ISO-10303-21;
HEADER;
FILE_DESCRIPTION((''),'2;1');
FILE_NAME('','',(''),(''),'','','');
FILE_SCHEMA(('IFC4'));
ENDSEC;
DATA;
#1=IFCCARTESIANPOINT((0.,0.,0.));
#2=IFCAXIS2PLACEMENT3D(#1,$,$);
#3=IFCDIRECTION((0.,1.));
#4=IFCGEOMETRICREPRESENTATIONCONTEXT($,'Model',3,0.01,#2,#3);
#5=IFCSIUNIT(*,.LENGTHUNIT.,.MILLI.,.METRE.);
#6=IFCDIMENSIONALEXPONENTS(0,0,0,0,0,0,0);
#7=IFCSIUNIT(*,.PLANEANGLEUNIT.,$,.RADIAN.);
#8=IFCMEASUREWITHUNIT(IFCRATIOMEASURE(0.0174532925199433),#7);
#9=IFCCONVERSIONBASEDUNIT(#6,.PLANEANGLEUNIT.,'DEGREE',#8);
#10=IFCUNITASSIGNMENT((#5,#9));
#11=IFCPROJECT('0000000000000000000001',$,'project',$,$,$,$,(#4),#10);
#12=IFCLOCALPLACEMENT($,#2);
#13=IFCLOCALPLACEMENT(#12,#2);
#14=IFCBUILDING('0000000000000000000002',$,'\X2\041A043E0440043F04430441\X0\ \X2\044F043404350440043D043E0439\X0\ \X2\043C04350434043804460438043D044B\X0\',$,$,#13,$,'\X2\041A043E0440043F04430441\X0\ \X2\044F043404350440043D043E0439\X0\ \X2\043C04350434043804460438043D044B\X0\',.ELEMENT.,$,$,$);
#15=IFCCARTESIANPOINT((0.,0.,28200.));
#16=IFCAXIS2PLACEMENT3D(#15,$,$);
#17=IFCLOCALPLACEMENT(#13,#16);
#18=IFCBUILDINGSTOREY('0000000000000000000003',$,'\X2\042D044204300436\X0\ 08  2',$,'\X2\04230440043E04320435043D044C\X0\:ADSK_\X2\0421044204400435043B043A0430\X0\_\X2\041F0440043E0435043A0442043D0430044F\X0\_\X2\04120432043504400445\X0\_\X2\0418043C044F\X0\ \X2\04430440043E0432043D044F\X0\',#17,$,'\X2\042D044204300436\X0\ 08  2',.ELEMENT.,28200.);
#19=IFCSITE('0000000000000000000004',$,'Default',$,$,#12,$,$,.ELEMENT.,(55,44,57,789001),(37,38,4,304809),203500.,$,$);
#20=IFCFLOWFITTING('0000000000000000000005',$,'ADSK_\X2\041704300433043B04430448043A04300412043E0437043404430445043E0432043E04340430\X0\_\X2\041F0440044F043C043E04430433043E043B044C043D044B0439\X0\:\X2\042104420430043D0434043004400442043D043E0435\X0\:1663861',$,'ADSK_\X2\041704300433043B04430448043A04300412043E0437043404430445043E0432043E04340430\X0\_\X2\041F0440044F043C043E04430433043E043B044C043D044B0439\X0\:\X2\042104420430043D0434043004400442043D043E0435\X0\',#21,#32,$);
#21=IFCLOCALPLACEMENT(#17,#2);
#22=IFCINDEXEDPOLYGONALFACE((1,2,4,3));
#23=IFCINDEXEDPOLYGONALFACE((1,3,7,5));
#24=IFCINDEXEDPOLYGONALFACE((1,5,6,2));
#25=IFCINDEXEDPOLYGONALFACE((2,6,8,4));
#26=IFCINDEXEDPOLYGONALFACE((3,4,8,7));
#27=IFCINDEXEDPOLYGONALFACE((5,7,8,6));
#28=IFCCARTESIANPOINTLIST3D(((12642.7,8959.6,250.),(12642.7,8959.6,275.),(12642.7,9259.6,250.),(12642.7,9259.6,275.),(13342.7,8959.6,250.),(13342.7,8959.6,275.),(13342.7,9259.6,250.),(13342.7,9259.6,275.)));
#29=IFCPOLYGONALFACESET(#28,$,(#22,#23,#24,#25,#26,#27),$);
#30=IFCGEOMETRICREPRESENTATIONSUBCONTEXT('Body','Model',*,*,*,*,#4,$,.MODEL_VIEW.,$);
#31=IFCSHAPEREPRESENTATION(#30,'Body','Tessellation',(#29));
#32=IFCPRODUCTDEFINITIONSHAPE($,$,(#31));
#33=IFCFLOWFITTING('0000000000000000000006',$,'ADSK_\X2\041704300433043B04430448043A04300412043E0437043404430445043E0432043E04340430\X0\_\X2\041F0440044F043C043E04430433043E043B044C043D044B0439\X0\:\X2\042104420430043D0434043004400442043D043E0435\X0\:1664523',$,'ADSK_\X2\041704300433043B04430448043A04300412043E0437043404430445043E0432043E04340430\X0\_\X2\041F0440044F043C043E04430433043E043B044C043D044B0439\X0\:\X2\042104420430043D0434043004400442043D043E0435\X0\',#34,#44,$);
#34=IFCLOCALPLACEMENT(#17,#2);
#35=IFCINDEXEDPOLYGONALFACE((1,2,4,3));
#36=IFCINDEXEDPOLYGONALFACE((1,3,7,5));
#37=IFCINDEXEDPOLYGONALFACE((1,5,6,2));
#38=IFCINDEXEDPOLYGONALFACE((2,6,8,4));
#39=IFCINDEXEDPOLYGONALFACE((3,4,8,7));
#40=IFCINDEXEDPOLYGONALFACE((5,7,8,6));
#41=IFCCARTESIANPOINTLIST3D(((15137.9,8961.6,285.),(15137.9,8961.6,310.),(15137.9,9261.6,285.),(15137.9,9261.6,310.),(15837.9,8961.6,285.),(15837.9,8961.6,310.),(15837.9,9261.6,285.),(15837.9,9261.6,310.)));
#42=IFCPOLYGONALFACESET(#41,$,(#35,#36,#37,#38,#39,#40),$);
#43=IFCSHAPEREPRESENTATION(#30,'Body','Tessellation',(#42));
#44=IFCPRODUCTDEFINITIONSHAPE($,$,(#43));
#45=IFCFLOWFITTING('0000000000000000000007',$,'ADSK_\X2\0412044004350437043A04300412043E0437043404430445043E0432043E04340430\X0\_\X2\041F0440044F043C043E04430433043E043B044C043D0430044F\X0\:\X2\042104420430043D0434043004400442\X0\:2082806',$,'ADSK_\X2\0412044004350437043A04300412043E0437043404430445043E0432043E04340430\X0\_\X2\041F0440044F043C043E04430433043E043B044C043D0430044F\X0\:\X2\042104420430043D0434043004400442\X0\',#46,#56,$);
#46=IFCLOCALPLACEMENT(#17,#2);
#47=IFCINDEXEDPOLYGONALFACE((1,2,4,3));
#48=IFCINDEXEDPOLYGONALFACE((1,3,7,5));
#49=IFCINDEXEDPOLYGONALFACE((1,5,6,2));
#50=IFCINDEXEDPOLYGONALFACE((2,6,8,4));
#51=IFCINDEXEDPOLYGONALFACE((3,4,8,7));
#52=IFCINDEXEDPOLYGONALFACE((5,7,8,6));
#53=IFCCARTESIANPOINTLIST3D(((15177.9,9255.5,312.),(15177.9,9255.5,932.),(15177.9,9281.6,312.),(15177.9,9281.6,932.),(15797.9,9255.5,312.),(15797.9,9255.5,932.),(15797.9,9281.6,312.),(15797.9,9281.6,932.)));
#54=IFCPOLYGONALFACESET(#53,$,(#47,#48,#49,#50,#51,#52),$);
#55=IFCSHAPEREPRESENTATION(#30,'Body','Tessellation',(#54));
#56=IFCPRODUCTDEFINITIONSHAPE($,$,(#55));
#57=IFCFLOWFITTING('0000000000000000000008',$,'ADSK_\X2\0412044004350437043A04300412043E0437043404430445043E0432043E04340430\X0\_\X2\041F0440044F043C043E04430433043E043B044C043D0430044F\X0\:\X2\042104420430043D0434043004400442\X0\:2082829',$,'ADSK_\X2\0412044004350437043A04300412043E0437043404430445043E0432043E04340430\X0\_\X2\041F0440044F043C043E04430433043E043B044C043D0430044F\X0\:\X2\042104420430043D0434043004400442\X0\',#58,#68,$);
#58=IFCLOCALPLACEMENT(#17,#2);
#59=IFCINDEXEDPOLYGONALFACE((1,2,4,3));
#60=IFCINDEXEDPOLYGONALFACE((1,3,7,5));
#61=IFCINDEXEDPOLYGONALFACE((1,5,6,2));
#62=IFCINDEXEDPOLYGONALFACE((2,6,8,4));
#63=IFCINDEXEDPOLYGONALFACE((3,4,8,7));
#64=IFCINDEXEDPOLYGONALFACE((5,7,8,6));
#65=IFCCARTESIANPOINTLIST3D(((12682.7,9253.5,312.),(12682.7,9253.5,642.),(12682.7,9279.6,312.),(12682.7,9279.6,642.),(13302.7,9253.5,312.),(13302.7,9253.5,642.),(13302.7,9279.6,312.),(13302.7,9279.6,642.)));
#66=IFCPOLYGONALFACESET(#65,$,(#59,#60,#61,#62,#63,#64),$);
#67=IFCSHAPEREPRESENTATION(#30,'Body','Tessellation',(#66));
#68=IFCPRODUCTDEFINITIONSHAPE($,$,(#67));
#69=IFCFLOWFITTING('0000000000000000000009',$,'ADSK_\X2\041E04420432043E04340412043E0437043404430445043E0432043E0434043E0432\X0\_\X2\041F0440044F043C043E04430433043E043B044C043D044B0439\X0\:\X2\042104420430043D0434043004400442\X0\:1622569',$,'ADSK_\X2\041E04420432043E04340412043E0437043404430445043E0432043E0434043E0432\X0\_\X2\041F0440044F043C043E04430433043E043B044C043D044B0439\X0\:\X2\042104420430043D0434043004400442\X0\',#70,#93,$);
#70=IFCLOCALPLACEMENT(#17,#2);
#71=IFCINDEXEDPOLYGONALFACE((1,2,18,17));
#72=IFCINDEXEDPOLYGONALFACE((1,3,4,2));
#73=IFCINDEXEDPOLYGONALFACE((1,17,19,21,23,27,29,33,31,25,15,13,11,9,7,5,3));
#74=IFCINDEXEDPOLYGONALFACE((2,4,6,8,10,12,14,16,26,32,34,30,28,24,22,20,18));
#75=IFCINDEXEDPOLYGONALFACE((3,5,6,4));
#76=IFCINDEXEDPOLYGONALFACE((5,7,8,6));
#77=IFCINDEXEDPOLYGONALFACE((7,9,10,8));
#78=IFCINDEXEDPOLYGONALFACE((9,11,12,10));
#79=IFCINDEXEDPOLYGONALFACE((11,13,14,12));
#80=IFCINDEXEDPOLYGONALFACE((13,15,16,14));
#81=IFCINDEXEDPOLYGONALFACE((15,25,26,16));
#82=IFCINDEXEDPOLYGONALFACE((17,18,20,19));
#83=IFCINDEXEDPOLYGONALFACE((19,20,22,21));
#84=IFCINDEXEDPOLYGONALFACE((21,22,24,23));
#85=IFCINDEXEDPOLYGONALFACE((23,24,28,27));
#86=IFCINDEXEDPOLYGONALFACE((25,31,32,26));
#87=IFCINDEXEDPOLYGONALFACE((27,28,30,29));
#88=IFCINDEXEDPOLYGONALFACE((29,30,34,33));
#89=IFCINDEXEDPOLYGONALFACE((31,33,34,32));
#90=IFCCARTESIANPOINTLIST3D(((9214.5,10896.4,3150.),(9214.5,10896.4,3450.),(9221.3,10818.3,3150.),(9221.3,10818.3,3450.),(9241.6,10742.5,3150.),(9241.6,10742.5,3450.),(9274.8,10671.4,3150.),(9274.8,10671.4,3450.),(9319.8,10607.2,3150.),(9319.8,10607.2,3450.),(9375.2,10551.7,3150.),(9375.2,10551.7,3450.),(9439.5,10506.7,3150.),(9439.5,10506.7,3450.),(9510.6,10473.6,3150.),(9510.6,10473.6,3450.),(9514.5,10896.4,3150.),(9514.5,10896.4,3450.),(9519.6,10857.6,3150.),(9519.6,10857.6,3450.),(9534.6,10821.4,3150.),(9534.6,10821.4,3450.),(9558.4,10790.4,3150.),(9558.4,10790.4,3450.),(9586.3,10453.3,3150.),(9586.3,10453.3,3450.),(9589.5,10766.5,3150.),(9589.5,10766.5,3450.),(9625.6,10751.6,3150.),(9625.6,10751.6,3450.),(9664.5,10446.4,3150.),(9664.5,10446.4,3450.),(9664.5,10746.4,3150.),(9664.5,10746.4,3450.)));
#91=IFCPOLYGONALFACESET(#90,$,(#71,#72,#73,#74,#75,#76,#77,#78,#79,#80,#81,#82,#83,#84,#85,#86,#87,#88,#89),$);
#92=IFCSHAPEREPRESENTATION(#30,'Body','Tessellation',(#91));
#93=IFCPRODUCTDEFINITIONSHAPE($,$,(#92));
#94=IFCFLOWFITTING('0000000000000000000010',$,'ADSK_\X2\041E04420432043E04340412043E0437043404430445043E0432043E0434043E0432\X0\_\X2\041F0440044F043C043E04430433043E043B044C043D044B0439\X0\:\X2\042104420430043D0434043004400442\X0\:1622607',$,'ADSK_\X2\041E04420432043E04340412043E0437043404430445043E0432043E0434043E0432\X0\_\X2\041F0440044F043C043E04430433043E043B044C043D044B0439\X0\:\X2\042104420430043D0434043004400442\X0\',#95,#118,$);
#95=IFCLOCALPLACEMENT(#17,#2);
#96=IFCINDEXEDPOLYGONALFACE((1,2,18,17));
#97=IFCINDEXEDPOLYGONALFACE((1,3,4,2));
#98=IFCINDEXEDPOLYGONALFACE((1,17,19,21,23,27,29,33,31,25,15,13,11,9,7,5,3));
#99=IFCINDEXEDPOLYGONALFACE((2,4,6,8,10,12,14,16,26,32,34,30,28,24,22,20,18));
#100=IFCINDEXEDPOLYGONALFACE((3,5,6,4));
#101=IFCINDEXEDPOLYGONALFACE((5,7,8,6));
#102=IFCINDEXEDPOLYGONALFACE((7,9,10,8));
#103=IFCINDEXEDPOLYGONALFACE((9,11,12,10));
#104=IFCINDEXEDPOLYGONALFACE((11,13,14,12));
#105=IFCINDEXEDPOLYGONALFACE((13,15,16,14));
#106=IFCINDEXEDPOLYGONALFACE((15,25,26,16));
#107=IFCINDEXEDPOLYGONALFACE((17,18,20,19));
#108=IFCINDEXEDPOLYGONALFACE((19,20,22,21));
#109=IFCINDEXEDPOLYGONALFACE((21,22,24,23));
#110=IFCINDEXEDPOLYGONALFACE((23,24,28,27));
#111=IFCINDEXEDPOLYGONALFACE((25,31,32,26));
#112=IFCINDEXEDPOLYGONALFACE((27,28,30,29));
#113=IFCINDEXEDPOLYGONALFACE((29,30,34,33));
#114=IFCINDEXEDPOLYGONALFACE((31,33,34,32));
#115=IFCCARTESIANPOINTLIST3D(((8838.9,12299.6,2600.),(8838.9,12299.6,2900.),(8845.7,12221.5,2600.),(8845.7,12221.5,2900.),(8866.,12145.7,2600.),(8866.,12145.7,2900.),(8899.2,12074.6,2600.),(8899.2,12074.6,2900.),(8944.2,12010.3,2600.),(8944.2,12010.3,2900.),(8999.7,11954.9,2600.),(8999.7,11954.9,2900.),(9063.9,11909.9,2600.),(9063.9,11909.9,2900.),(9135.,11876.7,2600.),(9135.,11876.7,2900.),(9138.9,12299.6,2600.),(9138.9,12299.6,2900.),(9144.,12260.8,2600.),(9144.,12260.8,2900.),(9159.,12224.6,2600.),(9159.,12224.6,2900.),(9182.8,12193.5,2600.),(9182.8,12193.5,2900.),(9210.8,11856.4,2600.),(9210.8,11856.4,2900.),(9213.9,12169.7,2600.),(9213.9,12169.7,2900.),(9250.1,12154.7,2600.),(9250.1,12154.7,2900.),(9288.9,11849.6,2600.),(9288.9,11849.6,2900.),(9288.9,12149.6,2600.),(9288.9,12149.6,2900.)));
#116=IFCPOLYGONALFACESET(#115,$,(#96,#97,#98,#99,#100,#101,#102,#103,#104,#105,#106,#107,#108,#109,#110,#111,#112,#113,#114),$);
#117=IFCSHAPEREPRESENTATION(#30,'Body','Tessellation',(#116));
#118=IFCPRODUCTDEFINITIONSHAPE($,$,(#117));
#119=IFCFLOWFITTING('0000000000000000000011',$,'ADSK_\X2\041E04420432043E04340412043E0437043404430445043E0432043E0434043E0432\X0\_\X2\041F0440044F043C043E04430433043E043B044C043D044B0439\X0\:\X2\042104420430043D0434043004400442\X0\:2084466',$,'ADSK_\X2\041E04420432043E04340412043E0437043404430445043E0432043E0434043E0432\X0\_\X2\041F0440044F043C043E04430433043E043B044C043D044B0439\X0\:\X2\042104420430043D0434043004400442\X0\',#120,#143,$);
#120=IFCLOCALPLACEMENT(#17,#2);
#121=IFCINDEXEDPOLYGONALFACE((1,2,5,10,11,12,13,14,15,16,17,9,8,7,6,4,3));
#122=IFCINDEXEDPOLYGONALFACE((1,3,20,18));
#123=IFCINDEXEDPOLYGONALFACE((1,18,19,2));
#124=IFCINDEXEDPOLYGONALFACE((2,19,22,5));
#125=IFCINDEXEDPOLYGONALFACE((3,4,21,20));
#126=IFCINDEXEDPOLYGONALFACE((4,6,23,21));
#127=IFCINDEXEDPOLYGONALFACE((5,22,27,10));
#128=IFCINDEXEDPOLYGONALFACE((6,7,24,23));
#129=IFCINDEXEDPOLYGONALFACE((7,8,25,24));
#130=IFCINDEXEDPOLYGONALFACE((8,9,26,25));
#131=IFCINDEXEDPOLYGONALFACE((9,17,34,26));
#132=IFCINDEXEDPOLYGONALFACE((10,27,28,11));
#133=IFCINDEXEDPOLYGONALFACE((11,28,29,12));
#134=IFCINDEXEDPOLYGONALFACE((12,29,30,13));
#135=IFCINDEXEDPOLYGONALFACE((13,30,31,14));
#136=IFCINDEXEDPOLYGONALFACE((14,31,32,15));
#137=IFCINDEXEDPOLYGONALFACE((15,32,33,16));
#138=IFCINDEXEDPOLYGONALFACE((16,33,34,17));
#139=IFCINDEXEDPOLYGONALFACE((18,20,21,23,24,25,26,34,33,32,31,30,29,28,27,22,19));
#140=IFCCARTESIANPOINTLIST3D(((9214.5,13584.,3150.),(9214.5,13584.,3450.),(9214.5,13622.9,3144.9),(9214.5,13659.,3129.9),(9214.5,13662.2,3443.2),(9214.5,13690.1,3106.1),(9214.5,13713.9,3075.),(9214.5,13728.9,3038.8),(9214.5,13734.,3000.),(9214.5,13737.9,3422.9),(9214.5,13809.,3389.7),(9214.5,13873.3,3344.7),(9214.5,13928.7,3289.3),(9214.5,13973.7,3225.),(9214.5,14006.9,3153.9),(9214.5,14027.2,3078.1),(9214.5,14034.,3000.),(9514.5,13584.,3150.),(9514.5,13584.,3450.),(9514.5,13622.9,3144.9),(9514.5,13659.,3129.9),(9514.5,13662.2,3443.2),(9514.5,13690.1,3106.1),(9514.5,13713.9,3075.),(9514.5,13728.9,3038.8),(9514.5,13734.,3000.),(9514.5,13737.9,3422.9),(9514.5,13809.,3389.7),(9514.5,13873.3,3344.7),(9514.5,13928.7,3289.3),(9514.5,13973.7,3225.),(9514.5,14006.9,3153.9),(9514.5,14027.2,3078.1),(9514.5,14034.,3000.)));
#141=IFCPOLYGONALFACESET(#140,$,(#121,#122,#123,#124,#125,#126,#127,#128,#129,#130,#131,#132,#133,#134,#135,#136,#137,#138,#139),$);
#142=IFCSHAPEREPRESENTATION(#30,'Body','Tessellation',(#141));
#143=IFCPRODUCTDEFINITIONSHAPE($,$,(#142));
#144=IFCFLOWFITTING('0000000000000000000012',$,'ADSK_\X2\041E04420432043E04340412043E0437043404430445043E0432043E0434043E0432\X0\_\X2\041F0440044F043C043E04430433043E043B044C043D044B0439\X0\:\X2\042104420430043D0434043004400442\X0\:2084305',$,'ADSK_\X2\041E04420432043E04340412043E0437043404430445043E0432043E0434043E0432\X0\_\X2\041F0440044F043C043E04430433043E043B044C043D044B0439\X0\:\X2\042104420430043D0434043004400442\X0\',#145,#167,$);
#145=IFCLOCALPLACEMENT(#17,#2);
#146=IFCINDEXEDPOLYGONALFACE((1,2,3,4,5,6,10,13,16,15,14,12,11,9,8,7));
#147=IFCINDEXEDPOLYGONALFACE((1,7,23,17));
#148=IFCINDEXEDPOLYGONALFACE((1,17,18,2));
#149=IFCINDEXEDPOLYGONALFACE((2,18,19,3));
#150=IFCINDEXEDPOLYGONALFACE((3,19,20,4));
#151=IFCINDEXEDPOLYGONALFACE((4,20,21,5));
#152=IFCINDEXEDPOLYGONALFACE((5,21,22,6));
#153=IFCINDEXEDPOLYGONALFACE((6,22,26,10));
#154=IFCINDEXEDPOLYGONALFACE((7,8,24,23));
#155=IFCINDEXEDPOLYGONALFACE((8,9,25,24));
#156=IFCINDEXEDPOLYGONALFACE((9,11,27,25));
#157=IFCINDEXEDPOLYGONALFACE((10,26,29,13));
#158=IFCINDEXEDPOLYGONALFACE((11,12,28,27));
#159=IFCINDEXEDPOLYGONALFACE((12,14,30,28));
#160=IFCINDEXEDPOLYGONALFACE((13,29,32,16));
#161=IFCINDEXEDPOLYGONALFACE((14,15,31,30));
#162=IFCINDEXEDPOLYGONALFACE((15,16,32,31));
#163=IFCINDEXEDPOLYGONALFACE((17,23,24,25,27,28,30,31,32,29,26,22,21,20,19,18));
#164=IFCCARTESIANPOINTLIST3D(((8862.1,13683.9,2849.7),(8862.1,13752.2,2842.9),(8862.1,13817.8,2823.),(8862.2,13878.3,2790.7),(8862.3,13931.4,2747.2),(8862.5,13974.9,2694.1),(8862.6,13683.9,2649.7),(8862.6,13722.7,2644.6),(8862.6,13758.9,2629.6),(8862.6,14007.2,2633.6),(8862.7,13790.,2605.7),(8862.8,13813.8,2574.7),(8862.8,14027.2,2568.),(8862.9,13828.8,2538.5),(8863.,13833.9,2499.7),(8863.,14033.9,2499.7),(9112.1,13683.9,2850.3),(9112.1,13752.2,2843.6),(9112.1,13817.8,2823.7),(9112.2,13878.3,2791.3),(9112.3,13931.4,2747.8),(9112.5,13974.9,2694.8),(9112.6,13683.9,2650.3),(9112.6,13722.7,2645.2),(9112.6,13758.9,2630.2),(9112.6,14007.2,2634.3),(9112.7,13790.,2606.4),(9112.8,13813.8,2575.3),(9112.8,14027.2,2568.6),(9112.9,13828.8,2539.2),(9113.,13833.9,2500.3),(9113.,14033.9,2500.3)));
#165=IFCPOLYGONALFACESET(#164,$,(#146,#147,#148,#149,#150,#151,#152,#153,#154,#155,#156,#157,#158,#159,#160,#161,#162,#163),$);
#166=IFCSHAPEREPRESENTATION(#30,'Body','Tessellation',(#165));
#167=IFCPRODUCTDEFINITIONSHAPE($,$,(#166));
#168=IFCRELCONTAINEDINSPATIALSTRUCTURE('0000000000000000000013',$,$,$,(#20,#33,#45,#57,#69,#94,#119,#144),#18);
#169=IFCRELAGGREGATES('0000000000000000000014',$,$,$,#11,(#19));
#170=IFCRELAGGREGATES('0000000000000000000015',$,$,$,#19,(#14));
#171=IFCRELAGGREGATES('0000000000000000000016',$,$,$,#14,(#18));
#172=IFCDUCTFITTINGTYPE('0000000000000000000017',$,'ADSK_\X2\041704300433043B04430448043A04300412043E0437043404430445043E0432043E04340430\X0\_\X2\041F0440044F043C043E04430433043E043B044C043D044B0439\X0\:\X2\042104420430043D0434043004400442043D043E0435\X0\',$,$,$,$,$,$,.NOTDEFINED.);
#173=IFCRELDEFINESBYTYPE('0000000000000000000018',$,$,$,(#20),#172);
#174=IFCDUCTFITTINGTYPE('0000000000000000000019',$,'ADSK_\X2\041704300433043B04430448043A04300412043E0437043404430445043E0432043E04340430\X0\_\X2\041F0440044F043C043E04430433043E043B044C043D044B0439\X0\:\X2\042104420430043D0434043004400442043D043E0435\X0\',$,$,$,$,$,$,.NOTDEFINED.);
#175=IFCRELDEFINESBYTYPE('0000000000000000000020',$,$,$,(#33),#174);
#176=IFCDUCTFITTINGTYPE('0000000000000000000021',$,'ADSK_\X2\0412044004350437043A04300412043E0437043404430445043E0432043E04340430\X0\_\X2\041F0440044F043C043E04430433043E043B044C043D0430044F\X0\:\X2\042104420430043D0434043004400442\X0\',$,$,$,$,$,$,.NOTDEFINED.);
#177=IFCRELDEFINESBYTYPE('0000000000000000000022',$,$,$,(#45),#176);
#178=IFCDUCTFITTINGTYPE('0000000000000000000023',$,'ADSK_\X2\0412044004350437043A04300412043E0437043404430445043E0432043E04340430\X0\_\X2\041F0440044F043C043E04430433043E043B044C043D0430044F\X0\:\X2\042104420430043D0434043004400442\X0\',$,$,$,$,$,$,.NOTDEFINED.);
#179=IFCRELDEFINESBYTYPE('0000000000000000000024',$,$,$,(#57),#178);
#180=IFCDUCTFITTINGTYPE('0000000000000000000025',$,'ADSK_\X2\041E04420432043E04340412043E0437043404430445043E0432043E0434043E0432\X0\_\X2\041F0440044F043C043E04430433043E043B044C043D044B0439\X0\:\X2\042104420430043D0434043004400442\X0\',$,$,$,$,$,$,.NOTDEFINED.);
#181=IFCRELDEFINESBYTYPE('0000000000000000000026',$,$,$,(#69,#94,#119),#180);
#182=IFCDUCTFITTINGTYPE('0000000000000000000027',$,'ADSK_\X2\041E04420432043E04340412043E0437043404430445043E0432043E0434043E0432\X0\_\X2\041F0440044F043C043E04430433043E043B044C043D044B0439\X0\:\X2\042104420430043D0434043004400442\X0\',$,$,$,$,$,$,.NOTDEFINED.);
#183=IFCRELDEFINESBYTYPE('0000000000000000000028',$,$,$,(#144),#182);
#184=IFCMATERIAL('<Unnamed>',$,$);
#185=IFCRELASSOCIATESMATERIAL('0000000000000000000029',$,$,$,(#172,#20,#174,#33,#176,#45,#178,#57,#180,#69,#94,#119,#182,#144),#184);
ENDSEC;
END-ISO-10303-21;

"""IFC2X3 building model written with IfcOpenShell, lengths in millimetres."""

from ifc_helpers import new_model, entity, si_unit, converted_unit, direction, frame, frame_2d, origin, origin_2d_with_axis, place, context, subcontext, project, spatial, polyline, circle_curve, parameter, trimmed, segment, composite_curve, rectangle, outline, extrude, source, transform, mapped, material, type_object, type_shapes, element, save


model = new_model("IFC2X3")

# Units and contexts
model_context = context("Model", 3, precision=0.01, world=origin(), true_north=direction((0.0, 1.0)))
body_context = subcontext(model_context, "Body", "Model", "MODEL_VIEW")
ifc_project = project(units=[si_unit("LENGTHUNIT", "METRE", prefix="MILLI"), converted_unit("PLANEANGLEUNIT", "DEGREE", entity("IfcRatioMeasure", 0.0174532925199433), si_unit("PLANEANGLEUNIT", "RADIAN"), dimensions=[0, 0, 0, 0, 0, 0, 0])], contexts=[model_context])

# Site, building, storey
site_placement = place(None, origin())
site = spatial("IfcSite", under=ifc_project, at=site_placement, Name="Default", CompositionType="ELEMENT", RefLatitude=(55, 44, 57, 789001), RefLongitude=(37, 38, 4, 304809), RefElevation=203500.0)
building_placement = place(site_placement, origin())
building = spatial("IfcBuilding", under=site, at=building_placement, Name="Корпус ядерной медицины", LongName="Корпус ядерной медицины", CompositionType="ELEMENT")
storey_placement = place(building_placement, frame((0.0, 0.0, 28200.0)))
storey = spatial("IfcBuildingStorey", under=building, at=storey_placement, Name="Этаж 08  2", ObjectType="Уровень:ADSK_Стрелка_Проектная_Вверх_Имя уровня", LongName="Этаж 08  2", CompositionType="ELEMENT", Elevation=28200.0)

# Flow fittings
ifc_material = material(Name="<Unnamed>")
duct_fitting_type_1 = type_object("IfcDuctFittingType", Name="ADSK_ЗаглушкаВоздуховода_Прямоугольный:Стандартное", PredefinedType="NOTDEFINED", material=ifc_material)
shared_shape_1 = source(origin(), body_context, "Body", "SweptSolid", [
    extrude(rectangle(XDim=25.0, YDim=700.0, at=origin_2d_with_axis()), frame((12.5, 0.0, -150.0)), (0.0, 0.0, 1.0), 300.0),
])
type_shapes(duct_fitting_type_1, [shared_shape_1])
flow_fitting_1_placement = place(storey_placement, frame((12992.7, 9109.6, 275.0), z_axis=(0.0, 1.0, 0.0), x_axis=(0.0, 0.0, -1.0)))
element("IfcFlowFitting", 1, at=flow_fitting_1_placement, inside=storey, type_object=duct_fitting_type_1, material=ifc_material, Name="ADSK_ЗаглушкаВоздуховода_Прямоугольный:Стандартное:1663861", ObjectType="ADSK_ЗаглушкаВоздуховода_Прямоугольный:Стандартное", context=body_context, shape_type="MappedRepresentation", body=[
    mapped(shared_shape_1, transform((0.0, 0.0, 0.0), scale=1.0)),
])
duct_fitting_type_2 = type_object("IfcDuctFittingType", Name="ADSK_ЗаглушкаВоздуховода_Прямоугольный:Стандартное", PredefinedType="NOTDEFINED", material=ifc_material)
shared_shape_2 = source(origin(), body_context, "Body", "SweptSolid", [
    extrude(rectangle(XDim=25.0, YDim=300.0, at=origin_2d_with_axis()), frame((12.5, 0.0, -350.0)), (0.0, 0.0, 1.0), 700.0),
])
type_shapes(duct_fitting_type_2, [shared_shape_2])
flow_fitting_2_placement = place(storey_placement, frame((15487.9, 9111.6, 310.0), z_axis=(1.0, 0.0, 0.0), x_axis=(0.0, 0.0, -1.0)))
element("IfcFlowFitting", 2, at=flow_fitting_2_placement, inside=storey, type_object=duct_fitting_type_2, material=ifc_material, Name="ADSK_ЗаглушкаВоздуховода_Прямоугольный:Стандартное:1664523", ObjectType="ADSK_ЗаглушкаВоздуховода_Прямоугольный:Стандартное", context=body_context, shape_type="MappedRepresentation", body=[
    mapped(shared_shape_2, transform((0.0, 0.0, 0.0), scale=1.0)),
])
duct_fitting_type_3 = type_object("IfcDuctFittingType", Name="ADSK_ВрезкаВоздуховода_Прямоугольная:Стандарт", PredefinedType="NOTDEFINED", material=ifc_material)
shared_shape_3 = source(origin(), body_context, "Body", "SweptSolid", [
    extrude(rectangle(XDim=26.1, YDim=620.0, at=origin_2d_with_axis()), frame((7.0, 0.0, -310.0)), (0.0, 0.0, 1.0), 620.0),
])
type_shapes(duct_fitting_type_3, [shared_shape_3])
flow_fitting_3_placement = place(storey_placement, frame((15487.9, 9261.6, 622.0), z_axis=(1.0, 0.0, 0.0), x_axis=(0.0, 1.0, 0.0)))
element("IfcFlowFitting", 3, at=flow_fitting_3_placement, inside=storey, type_object=duct_fitting_type_3, material=ifc_material, Name="ADSK_ВрезкаВоздуховода_Прямоугольная:Стандарт:2082806", ObjectType="ADSK_ВрезкаВоздуховода_Прямоугольная:Стандарт", context=body_context, shape_type="MappedRepresentation", body=[
    mapped(shared_shape_3, transform((0.0, 0.0, 0.0), scale=1.0)),
])
duct_fitting_type_4 = type_object("IfcDuctFittingType", Name="ADSK_ВрезкаВоздуховода_Прямоугольная:Стандарт", PredefinedType="NOTDEFINED", material=ifc_material)
shared_shape_4 = source(origin(), body_context, "Body", "SweptSolid", [
    extrude(rectangle(XDim=330.0, YDim=26.1, at=origin_2d_with_axis()), frame((7.0, 0.0, -310.0), z_axis=(0.0, 0.0, 1.0), x_axis=(0.0, -1.0, 0.0)), (0.0, 0.0, 1.0), 620.0),
])
type_shapes(duct_fitting_type_4, [shared_shape_4])
flow_fitting_4_placement = place(storey_placement, frame((12992.7, 9259.6, 477.0), z_axis=(1.0, 0.0, 0.0), x_axis=(0.0, 1.0, 0.0)))
element("IfcFlowFitting", 4, at=flow_fitting_4_placement, inside=storey, type_object=duct_fitting_type_4, material=ifc_material, Name="ADSK_ВрезкаВоздуховода_Прямоугольная:Стандарт:2082829", ObjectType="ADSK_ВрезкаВоздуховода_Прямоугольная:Стандарт", context=body_context, shape_type="MappedRepresentation", body=[
    mapped(shared_shape_4, transform((0.0, 0.0, 0.0), scale=1.0)),
])
duct_fitting_type_5 = type_object("IfcDuctFittingType", Name="ADSK_ОтводВоздуховодов_Прямоугольный:Стандарт", PredefinedType="NOTDEFINED", material=ifc_material)
shared_shape_5 = source(origin(), body_context, "Body", "SweptSolid", [
    extrude(outline(composite_curve([segment(polyline([(-300.0, -150.0), (0.0, -150.0)]), True, "CONTINUOUS"), segment(trimmed(circle_curve(frame_2d((150.0, -150.0), x_axis=(0.0, 1.0)), 150.0), [parameter(0.0)], [parameter(90.0)], True, "PARAMETER"), False, "CONTINUOUS"), segment(polyline([(150.0, 0.0), (150.0, 300.0)]), True, "CONTINUOUS"), segment(trimmed(circle_curve(frame_2d((150.0, -150.0), x_axis=(0.0, 1.0)), 450.0), [parameter(0.0)], [parameter(90.0)], True, "PARAMETER"), True, "CONTINUOUS")], self_intersect=False)), frame((-150.0, 150.0, -150.0), z_axis=(0.0, 0.0, 1.0), x_axis=(-1.0, 0.0, 0.0)), (0.0, 0.0, 1.0), 300.0),
])
type_shapes(duct_fitting_type_5, [shared_shape_5])
for number, where, z_axis, x_axis, name in (
    (5, (9364.5, 10596.4, 3300.0), (0.0, 0.0, 1.0), (0.0, -1.0, 0.0), "ADSK_ОтводВоздуховодов_Прямоугольный:Стандарт:1622569"),
    (6, (8988.9, 11999.6, 2750.0), (0.0, 0.0, 1.0), (0.0, -1.0, 0.0), "ADSK_ОтводВоздуховодов_Прямоугольный:Стандарт:1622607"),
    (7, (9364.5, 13884.0, 3300.0), (-1.0, 0.0, 0.0), (0.0, 1.0, 0.0), "ADSK_ОтводВоздуховодов_Прямоугольный:Стандарт:2084466"),
):
    element("IfcFlowFitting", number, at=place(storey_placement, frame(where, z_axis=z_axis, x_axis=x_axis)), inside=storey, type_object=duct_fitting_type_5, material=ifc_material, Name=name, ObjectType="ADSK_ОтводВоздуховодов_Прямоугольный:Стандарт", context=body_context, shape_type="MappedRepresentation", body=[
        mapped(shared_shape_5, transform((0.0, 0.0, 0.0), scale=1.0)),
    ])
duct_fitting_type_6 = type_object("IfcDuctFittingType", Name="ADSK_ОтводВоздуховодов_Прямоугольный:Стандарт", PredefinedType="NOTDEFINED", material=ifc_material)
shared_shape_6 = source(origin(), body_context, "Body", "SweptSolid", [
    extrude(outline(composite_curve([segment(polyline([(-225.0, -125.0), (-25.0, -125.0)]), True, "CONTINUOUS"), segment(trimmed(circle_curve(frame_2d((125.0, -125.0), x_axis=(0.0, 1.0)), 150.0), [parameter(0.0)], [parameter(90.0)], True, "PARAMETER"), False, "CONTINUOUS"), segment(polyline([(125.0, 25.0), (125.0, 225.0)]), True, "CONTINUOUS"), segment(trimmed(circle_curve(frame_2d((125.0, -125.0), x_axis=(0.0, 1.0)), 350.0), [parameter(0.0)], [parameter(90.0)], True, "PARAMETER"), True, "CONTINUOUS")], self_intersect=False)), frame((-125.0, 125.0, -125.0), z_axis=(0.0, 0.0, 1.0), x_axis=(-1.0, 0.0, 0.0)), (0.0, 0.0, 1.0), 250.0),
])
type_shapes(duct_fitting_type_6, [shared_shape_6])
flow_fitting_5_placement = place(storey_placement, frame((8987.3, 13933.9, 2750.0), z_axis=(-0.999997, 0.0, -0.002635), x_axis=(0.0, 1.0, 0.0)))
element("IfcFlowFitting", 8, at=flow_fitting_5_placement, inside=storey, type_object=duct_fitting_type_6, material=ifc_material, Name="ADSK_ОтводВоздуховодов_Прямоугольный:Стандарт:2084305", ObjectType="ADSK_ОтводВоздуховодов_Прямоугольный:Стандарт", context=body_context, shape_type="MappedRepresentation", body=[
    mapped(shared_shape_6, transform((0.0, 0.0, 0.0), scale=1.0)),
])

save(model, "model.ifc")
